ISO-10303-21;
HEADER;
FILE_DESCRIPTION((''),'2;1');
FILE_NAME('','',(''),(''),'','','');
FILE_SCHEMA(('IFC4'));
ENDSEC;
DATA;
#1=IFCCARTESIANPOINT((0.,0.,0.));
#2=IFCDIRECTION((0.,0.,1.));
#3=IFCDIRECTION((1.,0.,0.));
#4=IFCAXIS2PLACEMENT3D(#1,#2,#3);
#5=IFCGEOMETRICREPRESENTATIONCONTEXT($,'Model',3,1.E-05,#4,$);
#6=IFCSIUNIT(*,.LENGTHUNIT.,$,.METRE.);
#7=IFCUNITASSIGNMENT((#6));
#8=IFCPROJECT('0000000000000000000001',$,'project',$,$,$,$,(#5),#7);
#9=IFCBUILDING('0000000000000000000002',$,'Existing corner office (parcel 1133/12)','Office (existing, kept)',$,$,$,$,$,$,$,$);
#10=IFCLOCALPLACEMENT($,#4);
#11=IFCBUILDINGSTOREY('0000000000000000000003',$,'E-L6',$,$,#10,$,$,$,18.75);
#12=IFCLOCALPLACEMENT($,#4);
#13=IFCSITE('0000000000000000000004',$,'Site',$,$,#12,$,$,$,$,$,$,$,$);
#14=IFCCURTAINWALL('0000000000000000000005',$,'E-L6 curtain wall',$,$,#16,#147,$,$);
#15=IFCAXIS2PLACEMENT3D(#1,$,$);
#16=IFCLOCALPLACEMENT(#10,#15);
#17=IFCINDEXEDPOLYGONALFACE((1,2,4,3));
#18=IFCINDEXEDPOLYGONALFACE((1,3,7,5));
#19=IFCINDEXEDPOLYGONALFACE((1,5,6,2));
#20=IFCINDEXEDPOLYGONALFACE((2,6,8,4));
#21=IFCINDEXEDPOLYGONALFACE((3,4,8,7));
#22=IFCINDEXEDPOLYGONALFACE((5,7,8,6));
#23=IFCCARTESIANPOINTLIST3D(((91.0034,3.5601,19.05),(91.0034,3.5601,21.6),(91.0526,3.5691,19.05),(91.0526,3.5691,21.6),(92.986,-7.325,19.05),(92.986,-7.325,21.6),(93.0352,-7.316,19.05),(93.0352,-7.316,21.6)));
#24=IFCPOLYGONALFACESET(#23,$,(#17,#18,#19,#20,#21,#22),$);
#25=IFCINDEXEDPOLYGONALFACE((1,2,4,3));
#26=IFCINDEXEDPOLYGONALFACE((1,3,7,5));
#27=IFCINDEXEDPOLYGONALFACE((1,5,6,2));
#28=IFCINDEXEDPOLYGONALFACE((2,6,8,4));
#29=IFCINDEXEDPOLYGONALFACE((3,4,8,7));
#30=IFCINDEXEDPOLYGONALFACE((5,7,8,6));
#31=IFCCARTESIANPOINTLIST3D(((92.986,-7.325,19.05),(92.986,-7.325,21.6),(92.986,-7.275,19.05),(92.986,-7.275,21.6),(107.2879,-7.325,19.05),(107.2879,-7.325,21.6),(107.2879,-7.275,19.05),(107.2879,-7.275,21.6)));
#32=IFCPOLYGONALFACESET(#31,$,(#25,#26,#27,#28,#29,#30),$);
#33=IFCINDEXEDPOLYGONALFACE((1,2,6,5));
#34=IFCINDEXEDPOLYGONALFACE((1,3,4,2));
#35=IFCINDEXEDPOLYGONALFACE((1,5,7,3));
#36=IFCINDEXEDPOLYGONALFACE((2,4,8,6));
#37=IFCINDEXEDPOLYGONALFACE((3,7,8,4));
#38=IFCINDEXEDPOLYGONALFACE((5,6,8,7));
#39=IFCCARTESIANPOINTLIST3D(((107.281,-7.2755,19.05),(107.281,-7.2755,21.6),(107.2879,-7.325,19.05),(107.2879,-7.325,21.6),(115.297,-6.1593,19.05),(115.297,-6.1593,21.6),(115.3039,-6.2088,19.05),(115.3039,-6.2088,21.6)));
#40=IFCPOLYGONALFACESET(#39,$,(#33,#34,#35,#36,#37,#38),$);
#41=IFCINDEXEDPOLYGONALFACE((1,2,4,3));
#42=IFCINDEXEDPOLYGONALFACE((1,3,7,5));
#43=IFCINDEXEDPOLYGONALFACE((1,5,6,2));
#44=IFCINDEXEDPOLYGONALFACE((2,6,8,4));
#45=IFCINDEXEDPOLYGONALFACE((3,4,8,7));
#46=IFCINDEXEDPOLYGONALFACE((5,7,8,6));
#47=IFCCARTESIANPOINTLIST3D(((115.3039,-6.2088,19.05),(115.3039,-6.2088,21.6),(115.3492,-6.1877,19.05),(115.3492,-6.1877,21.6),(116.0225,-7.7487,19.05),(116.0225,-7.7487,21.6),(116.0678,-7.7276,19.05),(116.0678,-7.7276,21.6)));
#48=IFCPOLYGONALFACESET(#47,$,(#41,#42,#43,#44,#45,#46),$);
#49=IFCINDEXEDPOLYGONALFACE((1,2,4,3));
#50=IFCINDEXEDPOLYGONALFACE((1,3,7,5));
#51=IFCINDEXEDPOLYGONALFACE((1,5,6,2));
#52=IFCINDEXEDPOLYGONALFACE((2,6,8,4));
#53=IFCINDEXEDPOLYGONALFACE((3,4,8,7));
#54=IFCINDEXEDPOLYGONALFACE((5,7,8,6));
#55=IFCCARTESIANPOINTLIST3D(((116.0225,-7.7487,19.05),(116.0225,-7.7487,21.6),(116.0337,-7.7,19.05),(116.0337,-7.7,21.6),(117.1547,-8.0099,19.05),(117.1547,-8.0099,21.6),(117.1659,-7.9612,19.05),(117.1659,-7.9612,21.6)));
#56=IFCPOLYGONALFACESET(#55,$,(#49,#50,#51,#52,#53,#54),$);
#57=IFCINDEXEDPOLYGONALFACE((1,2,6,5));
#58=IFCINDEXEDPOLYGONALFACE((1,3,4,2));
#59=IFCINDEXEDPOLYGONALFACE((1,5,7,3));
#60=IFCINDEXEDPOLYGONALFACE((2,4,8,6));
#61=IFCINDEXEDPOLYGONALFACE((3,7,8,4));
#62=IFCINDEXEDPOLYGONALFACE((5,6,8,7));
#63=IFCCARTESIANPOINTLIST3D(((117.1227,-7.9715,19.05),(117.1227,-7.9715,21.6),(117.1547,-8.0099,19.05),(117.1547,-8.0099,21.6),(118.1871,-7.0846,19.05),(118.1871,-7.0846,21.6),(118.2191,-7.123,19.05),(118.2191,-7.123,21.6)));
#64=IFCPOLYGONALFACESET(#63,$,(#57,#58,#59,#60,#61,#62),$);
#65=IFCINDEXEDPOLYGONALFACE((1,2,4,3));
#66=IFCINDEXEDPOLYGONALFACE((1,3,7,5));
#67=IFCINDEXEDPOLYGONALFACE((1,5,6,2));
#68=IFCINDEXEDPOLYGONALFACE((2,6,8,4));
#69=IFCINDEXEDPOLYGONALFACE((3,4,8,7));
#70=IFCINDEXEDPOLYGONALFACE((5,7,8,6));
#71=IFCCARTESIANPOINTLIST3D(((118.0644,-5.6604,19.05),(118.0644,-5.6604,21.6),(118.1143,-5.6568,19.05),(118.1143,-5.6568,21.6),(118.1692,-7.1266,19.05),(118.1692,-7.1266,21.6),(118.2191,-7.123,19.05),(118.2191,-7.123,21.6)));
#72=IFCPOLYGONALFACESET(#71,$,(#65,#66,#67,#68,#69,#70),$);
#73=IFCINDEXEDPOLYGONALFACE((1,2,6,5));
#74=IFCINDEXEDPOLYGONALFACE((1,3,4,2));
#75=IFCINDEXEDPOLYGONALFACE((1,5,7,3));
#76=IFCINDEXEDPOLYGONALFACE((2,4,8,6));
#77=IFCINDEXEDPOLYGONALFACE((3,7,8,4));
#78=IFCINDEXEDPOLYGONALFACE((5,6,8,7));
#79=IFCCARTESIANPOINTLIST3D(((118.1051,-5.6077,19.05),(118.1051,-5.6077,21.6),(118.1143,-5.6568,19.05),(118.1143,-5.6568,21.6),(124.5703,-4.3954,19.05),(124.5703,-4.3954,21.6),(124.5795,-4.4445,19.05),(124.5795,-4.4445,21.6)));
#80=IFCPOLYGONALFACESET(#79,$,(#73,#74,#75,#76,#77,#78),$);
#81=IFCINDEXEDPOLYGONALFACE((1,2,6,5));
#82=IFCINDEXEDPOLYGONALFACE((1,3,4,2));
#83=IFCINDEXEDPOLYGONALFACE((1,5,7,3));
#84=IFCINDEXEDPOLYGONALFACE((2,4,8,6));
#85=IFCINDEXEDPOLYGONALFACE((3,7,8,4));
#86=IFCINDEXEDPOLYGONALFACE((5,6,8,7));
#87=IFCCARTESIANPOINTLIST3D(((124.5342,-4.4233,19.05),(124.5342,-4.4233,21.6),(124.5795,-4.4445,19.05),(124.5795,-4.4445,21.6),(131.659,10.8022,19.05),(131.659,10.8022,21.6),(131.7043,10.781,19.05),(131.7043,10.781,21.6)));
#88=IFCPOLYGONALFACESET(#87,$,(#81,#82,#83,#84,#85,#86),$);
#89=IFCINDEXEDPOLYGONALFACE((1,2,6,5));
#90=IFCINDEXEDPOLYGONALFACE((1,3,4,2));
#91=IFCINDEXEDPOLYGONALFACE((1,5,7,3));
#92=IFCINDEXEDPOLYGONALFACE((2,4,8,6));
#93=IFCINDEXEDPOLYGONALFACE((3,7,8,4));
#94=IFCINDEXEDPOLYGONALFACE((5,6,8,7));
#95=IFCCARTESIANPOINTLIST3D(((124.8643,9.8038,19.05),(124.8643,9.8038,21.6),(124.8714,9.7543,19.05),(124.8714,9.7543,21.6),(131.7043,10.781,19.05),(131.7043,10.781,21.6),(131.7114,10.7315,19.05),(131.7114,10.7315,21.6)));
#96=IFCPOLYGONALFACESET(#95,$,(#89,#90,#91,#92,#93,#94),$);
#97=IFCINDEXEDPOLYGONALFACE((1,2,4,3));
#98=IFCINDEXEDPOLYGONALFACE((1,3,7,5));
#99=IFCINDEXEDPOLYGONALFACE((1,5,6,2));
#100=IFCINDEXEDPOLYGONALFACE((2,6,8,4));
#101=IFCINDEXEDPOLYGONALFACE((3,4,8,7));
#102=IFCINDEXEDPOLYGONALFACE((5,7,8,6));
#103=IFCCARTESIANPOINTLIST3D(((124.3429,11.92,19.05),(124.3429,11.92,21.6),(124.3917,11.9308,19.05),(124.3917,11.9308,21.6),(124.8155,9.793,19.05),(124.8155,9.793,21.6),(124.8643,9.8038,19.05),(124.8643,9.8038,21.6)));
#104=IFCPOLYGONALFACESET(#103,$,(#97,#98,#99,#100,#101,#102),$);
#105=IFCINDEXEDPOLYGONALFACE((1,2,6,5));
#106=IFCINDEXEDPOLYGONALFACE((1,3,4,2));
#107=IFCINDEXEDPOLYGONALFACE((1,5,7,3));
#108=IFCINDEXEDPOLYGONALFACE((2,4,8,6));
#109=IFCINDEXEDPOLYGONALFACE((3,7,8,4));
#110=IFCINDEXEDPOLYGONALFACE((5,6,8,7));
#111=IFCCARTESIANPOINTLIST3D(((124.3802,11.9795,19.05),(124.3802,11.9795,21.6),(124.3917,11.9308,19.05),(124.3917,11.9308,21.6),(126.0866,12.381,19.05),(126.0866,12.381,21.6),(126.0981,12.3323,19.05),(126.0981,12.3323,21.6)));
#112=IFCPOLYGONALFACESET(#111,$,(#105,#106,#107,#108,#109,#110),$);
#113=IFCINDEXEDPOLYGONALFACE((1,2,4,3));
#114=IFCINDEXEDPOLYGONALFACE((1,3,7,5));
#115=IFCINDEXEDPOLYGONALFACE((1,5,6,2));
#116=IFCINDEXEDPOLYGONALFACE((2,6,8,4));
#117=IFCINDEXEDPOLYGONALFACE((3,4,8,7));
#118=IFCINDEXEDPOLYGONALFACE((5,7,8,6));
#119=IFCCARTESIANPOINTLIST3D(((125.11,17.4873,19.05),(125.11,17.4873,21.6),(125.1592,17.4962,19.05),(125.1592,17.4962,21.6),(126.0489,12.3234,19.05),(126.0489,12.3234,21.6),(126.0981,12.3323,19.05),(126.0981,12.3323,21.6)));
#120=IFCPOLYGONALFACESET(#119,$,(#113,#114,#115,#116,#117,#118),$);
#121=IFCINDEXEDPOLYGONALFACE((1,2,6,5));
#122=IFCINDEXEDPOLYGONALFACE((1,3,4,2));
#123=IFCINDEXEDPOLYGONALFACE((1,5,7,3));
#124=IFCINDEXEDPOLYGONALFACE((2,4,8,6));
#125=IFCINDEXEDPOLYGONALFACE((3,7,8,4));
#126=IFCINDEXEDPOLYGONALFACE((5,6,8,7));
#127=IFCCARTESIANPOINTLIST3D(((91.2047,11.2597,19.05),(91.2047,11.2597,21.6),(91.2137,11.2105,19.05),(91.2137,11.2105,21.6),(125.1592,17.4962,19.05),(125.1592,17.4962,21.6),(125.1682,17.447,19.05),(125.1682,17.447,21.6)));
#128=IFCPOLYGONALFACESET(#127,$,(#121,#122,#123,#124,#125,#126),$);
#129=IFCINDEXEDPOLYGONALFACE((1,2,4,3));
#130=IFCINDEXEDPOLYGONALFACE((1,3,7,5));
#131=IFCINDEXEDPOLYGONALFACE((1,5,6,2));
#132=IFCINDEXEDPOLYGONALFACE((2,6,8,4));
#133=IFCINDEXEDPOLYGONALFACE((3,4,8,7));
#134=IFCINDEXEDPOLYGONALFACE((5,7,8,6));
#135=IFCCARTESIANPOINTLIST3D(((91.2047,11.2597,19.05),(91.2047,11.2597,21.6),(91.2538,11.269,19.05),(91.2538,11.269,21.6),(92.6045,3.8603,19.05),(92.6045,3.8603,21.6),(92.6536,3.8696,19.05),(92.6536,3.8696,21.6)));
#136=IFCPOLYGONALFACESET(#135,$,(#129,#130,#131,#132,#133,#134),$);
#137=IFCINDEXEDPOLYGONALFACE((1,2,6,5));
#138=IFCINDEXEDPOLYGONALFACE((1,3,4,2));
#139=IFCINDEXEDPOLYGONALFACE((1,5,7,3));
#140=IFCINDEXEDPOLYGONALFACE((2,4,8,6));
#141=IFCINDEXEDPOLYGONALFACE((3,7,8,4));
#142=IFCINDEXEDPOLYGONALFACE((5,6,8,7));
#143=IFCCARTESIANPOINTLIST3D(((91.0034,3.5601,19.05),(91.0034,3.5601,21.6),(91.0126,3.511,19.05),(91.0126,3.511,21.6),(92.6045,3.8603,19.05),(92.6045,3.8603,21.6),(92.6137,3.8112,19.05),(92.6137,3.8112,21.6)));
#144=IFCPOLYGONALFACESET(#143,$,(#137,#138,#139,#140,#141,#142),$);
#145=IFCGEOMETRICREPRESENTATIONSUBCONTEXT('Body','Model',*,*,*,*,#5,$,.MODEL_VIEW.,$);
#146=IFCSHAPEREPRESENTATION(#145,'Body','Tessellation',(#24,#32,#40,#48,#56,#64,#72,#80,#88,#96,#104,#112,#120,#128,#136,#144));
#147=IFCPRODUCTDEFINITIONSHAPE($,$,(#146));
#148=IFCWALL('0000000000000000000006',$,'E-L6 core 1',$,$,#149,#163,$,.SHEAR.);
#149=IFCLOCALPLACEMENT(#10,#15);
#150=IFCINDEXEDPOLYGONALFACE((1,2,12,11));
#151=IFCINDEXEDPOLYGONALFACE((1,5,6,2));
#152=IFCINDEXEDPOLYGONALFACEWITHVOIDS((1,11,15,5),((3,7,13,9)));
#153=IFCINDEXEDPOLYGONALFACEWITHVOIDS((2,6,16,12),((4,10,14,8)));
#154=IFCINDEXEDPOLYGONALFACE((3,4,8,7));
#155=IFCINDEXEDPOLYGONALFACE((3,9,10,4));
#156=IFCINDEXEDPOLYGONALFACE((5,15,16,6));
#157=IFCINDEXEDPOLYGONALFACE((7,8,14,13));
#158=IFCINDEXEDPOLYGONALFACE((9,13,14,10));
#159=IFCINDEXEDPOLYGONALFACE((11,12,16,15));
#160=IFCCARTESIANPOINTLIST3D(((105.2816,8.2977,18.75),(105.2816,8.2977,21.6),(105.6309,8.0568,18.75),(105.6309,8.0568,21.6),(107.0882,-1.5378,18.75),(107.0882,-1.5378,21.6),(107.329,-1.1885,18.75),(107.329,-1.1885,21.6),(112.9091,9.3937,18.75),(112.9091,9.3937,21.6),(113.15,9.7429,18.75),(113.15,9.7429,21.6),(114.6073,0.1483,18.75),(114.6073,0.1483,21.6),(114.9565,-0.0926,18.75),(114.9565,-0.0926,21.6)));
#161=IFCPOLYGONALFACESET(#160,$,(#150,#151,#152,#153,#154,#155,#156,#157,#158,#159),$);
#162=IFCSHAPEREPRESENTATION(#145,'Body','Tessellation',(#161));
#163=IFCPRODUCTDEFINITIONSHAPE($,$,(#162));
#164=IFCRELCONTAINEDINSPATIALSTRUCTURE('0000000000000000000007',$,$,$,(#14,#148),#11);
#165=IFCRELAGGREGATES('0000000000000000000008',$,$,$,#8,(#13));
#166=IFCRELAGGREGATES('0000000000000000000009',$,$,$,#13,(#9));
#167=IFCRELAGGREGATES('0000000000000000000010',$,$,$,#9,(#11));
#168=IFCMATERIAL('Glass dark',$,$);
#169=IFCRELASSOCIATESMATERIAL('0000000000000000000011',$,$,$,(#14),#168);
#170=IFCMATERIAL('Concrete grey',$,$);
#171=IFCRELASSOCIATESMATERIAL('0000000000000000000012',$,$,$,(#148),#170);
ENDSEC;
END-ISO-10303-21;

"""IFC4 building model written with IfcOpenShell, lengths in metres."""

from ifc_helpers import new_model, si_unit, frame, origin_with_axes, place, context, subcontext, project, spatial, polyline, outline, extrude, material, element, save


model = new_model("IFC4")

# Units and contexts
model_context = context("Model", 3, precision=1e-05, world=origin_with_axes())
body_context = subcontext(model_context, "Body", "Model", "MODEL_VIEW")
ifc_project = project(units=[si_unit("LENGTHUNIT", "METRE")], contexts=[model_context])

# Site, building, storey
site_placement = place(None, origin_with_axes())
site = spatial("IfcSite", under=ifc_project, at=site_placement, Name="Site")
building = spatial("IfcBuilding", under=site, Name="Existing corner office (parcel 1133/12)", Description="Office (existing, kept)")
storey_placement = place(None, origin_with_axes())
storey = spatial("IfcBuildingStorey", under=building, at=storey_placement, Name="E-L6", Elevation=18.75)

# Shared definitions
ifc_material_1 = material(Name="Concrete grey")

# Curtain wall
ifc_material_2 = material(Name="Glass dark")
curtain_wall_placement = place(storey_placement, origin_with_axes())
element("IfcCurtainWall", 1, at=curtain_wall_placement, inside=storey, material=ifc_material_2, Name="E-L6 curtain wall", context=body_context, shape_type="SweptSolid", body=[
    extrude(outline(polyline([(91.0034, 3.5601), (92.986, -7.325), (93.0352, -7.316), (91.0526, 3.5691), (91.0034, 3.5601)])), frame((0.0, 0.0, 19.05), z_axis=(0.0, 0.0, 1.0), x_axis=(1.0, 0.0, 0.0)), (0.0, 0.0, 1.0), 2.55),
    extrude(outline(polyline([(92.986, -7.325), (107.2879, -7.325), (107.2879, -7.275), (92.986, -7.275), (92.986, -7.325)])), frame((0.0, 0.0, 19.05), z_axis=(0.0, 0.0, 1.0), x_axis=(1.0, 0.0, 0.0)), (0.0, 0.0, 1.0), 2.55),
    extrude(outline(polyline([(107.2879, -7.325), (115.3039, -6.2088), (115.297, -6.1593), (107.281, -7.2755), (107.2879, -7.325)])), frame((0.0, 0.0, 19.05), z_axis=(0.0, 0.0, 1.0), x_axis=(1.0, 0.0, 0.0)), (0.0, 0.0, 1.0), 2.55),
    extrude(outline(polyline([(115.3039, -6.2088), (116.0225, -7.7487), (116.0678, -7.7276), (115.3492, -6.1877), (115.3039, -6.2088)])), frame((0.0, 0.0, 19.05), z_axis=(0.0, 0.0, 1.0), x_axis=(1.0, 0.0, 0.0)), (0.0, 0.0, 1.0), 2.55),
    extrude(outline(polyline([(116.0225, -7.7487), (117.1547, -8.0099), (117.1659, -7.9612), (116.0337, -7.7), (116.0225, -7.7487)])), frame((0.0, 0.0, 19.05), z_axis=(0.0, 0.0, 1.0), x_axis=(1.0, 0.0, 0.0)), (0.0, 0.0, 1.0), 2.55),
    extrude(outline(polyline([(117.1547, -8.0099), (118.2191, -7.123), (118.1871, -7.0846), (117.1227, -7.9715), (117.1547, -8.0099)])), frame((0.0, 0.0, 19.05), z_axis=(0.0, 0.0, 1.0), x_axis=(1.0, 0.0, 0.0)), (0.0, 0.0, 1.0), 2.55),
    extrude(outline(polyline([(118.2191, -7.123), (118.1143, -5.6568), (118.0644, -5.6604), (118.1692, -7.1266), (118.2191, -7.123)])), frame((0.0, 0.0, 19.05), z_axis=(0.0, 0.0, 1.0), x_axis=(1.0, 0.0, 0.0)), (0.0, 0.0, 1.0), 2.55),
    extrude(outline(polyline([(118.1143, -5.6568), (124.5795, -4.4445), (124.5703, -4.3954), (118.1051, -5.6077), (118.1143, -5.6568)])), frame((0.0, 0.0, 19.05), z_axis=(0.0, 0.0, 1.0), x_axis=(1.0, 0.0, 0.0)), (0.0, 0.0, 1.0), 2.55),
    extrude(outline(polyline([(124.5795, -4.4445), (131.7043, 10.781), (131.659, 10.8022), (124.5342, -4.4233), (124.5795, -4.4445)])), frame((0.0, 0.0, 19.05), z_axis=(0.0, 0.0, 1.0), x_axis=(1.0, 0.0, 0.0)), (0.0, 0.0, 1.0), 2.55),
    extrude(outline(polyline([(131.7043, 10.781), (124.8643, 9.8038), (124.8714, 9.7543), (131.7114, 10.7315), (131.7043, 10.781)])), frame((0.0, 0.0, 19.05), z_axis=(0.0, 0.0, 1.0), x_axis=(1.0, 0.0, 0.0)), (0.0, 0.0, 1.0), 2.55),
    extrude(outline(polyline([(124.8643, 9.8038), (124.3917, 11.9308), (124.3429, 11.92), (124.8155, 9.793), (124.8643, 9.8038)])), frame((0.0, 0.0, 19.05), z_axis=(0.0, 0.0, 1.0), x_axis=(1.0, 0.0, 0.0)), (0.0, 0.0, 1.0), 2.55),
    extrude(outline(polyline([(124.3917, 11.9308), (126.0981, 12.3323), (126.0866, 12.381), (124.3802, 11.9795), (124.3917, 11.9308)])), frame((0.0, 0.0, 19.05), z_axis=(0.0, 0.0, 1.0), x_axis=(1.0, 0.0, 0.0)), (0.0, 0.0, 1.0), 2.55),
    extrude(outline(polyline([(126.0981, 12.3323), (125.1592, 17.4962), (125.11, 17.4873), (126.0489, 12.3234), (126.0981, 12.3323)])), frame((0.0, 0.0, 19.05), z_axis=(0.0, 0.0, 1.0), x_axis=(1.0, 0.0, 0.0)), (0.0, 0.0, 1.0), 2.55),
    extrude(outline(polyline([(125.1592, 17.4962), (91.2047, 11.2597), (91.2137, 11.2105), (125.1682, 17.447), (125.1592, 17.4962)])), frame((0.0, 0.0, 19.05), z_axis=(0.0, 0.0, 1.0), x_axis=(1.0, 0.0, 0.0)), (0.0, 0.0, 1.0), 2.55),
    extrude(outline(polyline([(91.2047, 11.2597), (92.6045, 3.8603), (92.6536, 3.8696), (91.2538, 11.269), (91.2047, 11.2597)])), frame((0.0, 0.0, 19.05), z_axis=(0.0, 0.0, 1.0), x_axis=(1.0, 0.0, 0.0)), (0.0, 0.0, 1.0), 2.55),
    extrude(outline(polyline([(92.6045, 3.8603), (91.0034, 3.5601), (91.0126, 3.511), (92.6137, 3.8112), (92.6045, 3.8603)])), frame((0.0, 0.0, 19.05), z_axis=(0.0, 0.0, 1.0), x_axis=(1.0, 0.0, 0.0)), (0.0, 0.0, 1.0), 2.55),
])

# Wall
wall_placement = place(storey_placement, origin_with_axes())
element("IfcWall", 2, at=wall_placement, inside=storey, material=ifc_material_1, Name="E-L6 core 1", PredefinedType="SHEAR", context=body_context, shape_type="SweptSolid", body=[
    extrude(outline(polyline([(113.15, 9.7429), (105.2816, 8.2977), (107.0882, -1.5378), (114.9565, -0.0926), (113.15, 9.7429)]), holes=[polyline([(112.9091, 9.3937), (105.6309, 8.0568), (107.329, -1.1885), (114.6073, 0.1483), (112.9091, 9.3937)])]), frame((0.0, 0.0, 18.75), z_axis=(0.0, 0.0, 1.0), x_axis=(1.0, 0.0, 0.0)), (0.0, 0.0, 1.0), 2.85),
])

save(model, "model.ifc")
